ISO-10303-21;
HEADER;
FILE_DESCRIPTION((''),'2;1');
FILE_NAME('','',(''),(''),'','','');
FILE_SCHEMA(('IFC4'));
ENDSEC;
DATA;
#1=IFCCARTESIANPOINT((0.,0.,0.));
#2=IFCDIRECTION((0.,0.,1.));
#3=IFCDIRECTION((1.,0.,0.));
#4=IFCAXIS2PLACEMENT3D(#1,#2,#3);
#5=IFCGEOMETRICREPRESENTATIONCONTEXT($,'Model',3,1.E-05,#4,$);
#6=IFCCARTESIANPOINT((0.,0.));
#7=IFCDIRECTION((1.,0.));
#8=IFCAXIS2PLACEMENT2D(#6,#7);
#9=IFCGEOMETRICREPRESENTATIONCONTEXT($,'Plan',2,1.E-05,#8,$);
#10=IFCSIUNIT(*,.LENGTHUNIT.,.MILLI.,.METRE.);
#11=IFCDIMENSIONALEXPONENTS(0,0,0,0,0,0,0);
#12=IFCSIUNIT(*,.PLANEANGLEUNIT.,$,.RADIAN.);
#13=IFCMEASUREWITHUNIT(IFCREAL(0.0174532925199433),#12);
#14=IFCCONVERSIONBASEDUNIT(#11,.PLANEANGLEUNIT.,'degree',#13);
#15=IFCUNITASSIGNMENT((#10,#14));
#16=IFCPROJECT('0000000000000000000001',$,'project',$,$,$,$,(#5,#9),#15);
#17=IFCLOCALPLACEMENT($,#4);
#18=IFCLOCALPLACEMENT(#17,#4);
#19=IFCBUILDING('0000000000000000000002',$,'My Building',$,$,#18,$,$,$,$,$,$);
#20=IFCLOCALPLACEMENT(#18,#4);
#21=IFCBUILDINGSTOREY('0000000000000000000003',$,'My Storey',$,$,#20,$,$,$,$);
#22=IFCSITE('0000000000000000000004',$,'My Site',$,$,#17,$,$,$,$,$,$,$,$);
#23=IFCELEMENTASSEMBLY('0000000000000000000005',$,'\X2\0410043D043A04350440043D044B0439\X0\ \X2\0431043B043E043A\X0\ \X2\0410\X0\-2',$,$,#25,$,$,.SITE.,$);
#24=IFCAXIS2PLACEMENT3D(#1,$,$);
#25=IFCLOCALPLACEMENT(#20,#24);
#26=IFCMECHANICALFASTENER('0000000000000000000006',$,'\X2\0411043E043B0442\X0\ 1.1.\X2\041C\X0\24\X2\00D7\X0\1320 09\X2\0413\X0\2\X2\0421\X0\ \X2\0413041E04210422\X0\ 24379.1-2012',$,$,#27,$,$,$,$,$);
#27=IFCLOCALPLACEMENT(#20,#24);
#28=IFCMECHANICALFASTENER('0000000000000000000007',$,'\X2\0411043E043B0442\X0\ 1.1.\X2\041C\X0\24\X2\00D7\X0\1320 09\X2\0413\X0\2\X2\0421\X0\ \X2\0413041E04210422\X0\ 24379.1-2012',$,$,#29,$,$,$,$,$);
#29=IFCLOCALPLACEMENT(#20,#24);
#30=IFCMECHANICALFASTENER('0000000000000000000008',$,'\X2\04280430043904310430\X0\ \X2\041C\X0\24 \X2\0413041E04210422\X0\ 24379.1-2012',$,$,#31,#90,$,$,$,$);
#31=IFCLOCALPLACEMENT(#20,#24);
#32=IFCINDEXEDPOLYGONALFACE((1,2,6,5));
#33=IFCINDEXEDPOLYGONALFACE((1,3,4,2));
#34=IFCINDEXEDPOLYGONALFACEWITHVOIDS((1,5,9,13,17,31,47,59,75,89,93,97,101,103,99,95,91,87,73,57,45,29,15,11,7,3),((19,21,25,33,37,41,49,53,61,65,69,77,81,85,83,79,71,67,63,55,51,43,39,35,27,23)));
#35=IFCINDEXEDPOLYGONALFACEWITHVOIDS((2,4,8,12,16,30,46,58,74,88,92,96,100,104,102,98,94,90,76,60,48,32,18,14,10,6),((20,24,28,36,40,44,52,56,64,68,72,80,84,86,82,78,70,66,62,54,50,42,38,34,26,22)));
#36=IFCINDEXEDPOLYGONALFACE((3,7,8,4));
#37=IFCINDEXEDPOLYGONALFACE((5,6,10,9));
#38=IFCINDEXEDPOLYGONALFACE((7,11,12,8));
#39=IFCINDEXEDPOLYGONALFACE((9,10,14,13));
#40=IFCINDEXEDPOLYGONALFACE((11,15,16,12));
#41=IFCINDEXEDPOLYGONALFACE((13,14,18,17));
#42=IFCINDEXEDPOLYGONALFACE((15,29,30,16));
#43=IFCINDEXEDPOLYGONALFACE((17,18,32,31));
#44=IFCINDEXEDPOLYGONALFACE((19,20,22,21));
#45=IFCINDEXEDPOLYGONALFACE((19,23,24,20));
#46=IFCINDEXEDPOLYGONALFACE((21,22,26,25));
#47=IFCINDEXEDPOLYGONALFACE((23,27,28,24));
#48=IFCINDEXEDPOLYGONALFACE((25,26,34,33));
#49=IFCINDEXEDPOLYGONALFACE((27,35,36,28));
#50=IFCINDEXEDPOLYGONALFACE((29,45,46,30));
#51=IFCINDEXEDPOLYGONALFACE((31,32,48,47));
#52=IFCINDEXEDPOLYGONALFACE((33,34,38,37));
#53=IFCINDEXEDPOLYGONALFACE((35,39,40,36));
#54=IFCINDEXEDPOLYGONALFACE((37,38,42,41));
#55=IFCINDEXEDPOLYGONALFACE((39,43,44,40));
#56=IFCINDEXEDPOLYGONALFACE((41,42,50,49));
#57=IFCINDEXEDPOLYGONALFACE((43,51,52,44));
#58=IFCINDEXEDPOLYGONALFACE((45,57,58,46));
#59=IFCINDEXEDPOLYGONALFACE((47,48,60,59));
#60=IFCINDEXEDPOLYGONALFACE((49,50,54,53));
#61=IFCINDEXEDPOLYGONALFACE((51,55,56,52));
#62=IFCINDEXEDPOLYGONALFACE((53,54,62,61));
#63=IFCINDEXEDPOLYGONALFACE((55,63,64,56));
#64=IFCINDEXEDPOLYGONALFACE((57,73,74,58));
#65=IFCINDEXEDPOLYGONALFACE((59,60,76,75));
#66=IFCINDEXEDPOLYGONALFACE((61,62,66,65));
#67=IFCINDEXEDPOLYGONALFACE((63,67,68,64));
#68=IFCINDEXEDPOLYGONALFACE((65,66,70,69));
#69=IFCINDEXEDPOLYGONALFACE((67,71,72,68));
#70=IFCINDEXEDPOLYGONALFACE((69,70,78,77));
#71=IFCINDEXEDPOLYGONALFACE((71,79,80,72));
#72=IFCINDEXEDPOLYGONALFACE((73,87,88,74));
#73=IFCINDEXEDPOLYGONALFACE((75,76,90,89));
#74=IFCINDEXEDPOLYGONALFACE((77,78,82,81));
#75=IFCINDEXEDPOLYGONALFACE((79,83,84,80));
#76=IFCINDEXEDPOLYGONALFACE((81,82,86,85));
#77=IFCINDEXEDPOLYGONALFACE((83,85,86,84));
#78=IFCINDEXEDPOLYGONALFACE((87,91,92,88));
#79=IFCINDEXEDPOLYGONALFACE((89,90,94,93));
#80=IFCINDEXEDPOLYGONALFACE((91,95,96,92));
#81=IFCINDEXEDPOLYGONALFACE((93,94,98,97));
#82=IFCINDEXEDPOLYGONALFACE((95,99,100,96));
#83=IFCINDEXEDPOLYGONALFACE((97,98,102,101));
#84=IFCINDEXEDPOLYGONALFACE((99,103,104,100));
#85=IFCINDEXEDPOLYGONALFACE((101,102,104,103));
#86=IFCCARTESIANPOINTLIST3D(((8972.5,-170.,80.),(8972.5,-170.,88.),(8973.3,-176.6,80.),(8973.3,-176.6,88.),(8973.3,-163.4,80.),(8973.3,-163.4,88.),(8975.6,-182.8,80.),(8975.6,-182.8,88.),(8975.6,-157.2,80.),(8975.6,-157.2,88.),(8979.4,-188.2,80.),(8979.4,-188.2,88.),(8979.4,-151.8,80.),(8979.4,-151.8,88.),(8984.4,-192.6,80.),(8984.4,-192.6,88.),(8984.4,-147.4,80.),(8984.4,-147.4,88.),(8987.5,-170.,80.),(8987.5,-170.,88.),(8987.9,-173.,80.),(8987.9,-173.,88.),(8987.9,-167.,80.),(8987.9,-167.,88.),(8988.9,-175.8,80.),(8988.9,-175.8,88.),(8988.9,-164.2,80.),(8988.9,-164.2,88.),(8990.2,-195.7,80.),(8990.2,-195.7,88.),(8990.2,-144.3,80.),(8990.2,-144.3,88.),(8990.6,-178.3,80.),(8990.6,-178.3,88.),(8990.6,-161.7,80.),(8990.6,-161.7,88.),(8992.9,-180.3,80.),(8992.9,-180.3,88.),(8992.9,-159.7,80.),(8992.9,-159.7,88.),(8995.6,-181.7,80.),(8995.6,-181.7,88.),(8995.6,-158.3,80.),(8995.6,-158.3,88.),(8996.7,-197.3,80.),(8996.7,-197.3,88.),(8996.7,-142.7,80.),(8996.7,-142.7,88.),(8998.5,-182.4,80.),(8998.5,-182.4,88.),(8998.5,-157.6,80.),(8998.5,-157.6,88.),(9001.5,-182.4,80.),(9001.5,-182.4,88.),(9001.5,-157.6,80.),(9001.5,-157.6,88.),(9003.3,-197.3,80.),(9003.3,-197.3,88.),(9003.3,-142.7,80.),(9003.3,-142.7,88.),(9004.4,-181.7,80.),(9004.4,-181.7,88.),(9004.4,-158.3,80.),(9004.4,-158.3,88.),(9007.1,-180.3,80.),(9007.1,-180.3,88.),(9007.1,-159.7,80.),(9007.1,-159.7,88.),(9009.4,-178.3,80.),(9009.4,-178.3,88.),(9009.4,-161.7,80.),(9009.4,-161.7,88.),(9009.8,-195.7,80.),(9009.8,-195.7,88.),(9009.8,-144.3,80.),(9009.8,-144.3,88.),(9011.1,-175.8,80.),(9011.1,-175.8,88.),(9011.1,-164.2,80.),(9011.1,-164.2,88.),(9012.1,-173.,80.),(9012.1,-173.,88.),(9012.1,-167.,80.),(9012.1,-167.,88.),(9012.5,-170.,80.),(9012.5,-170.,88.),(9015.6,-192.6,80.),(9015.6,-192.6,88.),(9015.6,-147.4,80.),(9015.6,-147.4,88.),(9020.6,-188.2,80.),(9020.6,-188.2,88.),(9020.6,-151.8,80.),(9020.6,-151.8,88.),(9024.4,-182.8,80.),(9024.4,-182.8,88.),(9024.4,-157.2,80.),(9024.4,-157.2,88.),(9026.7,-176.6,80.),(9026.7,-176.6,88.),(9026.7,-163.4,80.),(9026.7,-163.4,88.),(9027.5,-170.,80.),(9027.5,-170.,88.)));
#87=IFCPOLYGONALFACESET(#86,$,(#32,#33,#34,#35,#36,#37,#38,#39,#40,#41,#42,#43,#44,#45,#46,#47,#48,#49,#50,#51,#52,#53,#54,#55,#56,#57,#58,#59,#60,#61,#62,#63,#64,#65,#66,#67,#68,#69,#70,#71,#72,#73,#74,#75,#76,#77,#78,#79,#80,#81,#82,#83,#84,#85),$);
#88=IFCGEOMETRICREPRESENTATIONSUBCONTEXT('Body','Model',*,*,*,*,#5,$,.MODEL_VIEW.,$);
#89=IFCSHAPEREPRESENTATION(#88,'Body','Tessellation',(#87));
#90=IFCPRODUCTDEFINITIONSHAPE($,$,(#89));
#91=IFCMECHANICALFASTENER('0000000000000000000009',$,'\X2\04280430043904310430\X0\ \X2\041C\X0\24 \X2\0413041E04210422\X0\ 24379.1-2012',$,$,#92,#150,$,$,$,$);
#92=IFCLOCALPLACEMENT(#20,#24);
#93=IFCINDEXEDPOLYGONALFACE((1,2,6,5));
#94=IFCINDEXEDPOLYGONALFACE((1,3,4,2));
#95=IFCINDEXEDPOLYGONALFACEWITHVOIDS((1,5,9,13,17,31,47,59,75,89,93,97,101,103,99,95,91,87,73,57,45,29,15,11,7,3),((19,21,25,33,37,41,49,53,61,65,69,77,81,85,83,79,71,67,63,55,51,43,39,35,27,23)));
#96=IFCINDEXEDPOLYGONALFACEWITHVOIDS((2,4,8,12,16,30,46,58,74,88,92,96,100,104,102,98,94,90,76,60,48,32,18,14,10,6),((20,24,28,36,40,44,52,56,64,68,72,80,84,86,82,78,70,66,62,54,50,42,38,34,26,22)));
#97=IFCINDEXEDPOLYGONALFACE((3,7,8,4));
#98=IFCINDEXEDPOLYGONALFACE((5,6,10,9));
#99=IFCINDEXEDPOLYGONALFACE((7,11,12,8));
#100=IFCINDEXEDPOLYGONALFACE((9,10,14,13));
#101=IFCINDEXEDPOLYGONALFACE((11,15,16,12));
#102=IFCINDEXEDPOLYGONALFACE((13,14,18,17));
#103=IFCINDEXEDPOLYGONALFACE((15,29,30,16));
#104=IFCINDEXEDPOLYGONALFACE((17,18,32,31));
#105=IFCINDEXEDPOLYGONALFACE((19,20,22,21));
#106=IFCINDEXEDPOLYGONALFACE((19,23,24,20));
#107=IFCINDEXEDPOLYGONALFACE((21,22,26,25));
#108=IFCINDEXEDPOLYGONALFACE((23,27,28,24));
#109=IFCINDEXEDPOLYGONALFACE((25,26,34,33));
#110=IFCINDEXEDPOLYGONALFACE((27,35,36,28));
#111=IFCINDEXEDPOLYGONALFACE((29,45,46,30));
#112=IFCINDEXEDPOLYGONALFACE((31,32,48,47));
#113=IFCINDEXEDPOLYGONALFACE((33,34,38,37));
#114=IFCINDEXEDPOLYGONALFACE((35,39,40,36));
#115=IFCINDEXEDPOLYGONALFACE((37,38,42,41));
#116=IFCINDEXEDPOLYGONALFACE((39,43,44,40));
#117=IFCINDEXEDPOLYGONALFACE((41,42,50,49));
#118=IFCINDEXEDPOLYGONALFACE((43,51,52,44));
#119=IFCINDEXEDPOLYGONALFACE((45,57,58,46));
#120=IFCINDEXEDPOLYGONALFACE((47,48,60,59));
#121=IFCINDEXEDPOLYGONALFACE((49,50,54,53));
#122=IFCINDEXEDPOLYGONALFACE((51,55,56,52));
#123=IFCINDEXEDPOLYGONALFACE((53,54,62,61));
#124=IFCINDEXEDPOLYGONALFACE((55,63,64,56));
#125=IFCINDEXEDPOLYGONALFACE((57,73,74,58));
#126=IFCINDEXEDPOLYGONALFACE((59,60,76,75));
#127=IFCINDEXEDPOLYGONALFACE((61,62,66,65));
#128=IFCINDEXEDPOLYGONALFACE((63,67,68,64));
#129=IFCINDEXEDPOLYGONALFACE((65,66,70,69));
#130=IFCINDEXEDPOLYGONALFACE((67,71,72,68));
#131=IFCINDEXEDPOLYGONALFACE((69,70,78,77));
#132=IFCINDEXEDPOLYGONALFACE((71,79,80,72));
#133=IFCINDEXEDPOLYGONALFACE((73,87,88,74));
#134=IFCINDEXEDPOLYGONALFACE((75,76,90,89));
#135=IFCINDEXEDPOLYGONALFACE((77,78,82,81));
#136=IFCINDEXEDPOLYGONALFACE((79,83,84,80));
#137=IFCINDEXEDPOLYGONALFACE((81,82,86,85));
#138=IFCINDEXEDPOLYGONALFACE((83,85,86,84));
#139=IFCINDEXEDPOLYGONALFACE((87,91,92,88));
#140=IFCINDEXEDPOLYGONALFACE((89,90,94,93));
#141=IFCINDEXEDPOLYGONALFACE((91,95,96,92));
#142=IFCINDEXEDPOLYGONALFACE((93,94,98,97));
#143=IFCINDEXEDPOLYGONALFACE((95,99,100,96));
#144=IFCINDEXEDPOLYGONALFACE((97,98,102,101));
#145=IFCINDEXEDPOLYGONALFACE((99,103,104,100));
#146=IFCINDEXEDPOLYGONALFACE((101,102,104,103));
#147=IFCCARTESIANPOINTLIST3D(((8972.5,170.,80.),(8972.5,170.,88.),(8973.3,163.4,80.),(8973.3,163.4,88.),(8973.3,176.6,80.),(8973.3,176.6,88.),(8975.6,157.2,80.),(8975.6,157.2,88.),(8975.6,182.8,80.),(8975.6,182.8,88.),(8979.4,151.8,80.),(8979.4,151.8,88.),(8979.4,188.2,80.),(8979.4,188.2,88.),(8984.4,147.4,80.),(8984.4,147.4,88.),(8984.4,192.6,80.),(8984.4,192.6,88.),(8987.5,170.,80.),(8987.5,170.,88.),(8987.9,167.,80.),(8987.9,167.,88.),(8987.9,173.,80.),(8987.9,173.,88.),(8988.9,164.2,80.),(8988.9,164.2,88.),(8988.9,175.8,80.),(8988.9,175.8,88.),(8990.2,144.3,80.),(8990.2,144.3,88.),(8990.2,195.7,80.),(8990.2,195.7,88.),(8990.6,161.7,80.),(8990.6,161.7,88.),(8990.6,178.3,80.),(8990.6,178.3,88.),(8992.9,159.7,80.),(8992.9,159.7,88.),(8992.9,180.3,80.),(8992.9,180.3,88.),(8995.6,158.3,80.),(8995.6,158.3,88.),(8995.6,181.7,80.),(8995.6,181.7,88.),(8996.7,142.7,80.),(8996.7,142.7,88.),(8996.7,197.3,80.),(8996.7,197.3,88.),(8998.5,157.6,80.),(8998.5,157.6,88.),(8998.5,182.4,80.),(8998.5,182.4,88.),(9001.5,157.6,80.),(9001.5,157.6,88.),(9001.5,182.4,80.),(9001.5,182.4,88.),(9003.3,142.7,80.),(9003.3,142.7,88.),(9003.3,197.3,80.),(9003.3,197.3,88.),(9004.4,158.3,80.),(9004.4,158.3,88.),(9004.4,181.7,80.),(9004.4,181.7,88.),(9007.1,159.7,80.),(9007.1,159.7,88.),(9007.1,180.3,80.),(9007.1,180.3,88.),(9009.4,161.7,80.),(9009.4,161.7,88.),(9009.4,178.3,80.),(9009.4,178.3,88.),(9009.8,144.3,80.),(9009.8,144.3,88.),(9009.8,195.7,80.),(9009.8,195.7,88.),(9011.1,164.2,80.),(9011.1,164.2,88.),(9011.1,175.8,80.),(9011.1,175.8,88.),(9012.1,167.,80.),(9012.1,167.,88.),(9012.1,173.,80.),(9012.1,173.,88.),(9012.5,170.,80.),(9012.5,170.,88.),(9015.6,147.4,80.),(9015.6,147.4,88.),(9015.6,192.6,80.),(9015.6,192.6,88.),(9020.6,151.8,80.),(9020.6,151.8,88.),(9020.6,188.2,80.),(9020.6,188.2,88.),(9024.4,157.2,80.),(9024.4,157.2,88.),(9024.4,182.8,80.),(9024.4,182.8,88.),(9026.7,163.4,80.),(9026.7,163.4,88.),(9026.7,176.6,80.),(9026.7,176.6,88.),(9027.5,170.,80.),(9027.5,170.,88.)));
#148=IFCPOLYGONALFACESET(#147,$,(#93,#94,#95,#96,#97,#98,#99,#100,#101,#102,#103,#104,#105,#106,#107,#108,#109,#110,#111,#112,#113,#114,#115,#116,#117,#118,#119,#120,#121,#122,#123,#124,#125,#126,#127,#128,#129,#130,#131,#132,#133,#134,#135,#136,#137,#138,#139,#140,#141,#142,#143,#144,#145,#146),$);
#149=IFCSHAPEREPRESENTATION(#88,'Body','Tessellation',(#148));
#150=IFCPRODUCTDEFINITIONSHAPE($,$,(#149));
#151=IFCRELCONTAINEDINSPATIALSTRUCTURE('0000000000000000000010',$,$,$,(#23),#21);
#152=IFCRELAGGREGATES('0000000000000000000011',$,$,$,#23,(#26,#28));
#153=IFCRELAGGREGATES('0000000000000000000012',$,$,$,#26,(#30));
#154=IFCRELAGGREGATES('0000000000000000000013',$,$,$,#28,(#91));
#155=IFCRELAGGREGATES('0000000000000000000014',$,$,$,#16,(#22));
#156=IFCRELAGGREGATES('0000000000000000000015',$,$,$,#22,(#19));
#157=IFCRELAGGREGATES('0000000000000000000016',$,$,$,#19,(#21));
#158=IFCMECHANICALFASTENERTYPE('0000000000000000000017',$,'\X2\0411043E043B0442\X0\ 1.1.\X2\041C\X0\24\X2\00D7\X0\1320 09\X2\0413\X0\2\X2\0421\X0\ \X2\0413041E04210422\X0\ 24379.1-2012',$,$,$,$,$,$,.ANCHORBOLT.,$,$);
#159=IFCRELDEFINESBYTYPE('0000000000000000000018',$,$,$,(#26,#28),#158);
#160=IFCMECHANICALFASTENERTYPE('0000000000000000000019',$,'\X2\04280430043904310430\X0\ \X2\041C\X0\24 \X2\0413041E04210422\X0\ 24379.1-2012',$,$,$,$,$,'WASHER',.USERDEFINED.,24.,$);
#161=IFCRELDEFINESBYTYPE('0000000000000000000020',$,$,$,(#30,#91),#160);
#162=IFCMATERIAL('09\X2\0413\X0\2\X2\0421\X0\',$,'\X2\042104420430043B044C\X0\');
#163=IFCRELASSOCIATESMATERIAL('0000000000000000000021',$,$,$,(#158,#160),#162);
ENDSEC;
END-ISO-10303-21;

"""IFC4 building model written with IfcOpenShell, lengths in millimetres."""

from ifc_helpers import new_model, entity, si_unit, converted_unit, frame, origin_with_axes, origin_2d_with_axis, place, context, subcontext, project, spatial, polyline, outline, extrude, source, transform, mapped, material, type_object, type_shapes, element, aggregate, save


model = new_model("IFC4")

# Units and contexts
model_context = context("Model", 3, precision=1e-05, world=origin_with_axes())
plan_context = context("Plan", 2, precision=1e-05, world=origin_2d_with_axis())
body_context = subcontext(model_context, "Body", "Model", "MODEL_VIEW")
ifc_project = project(units=[si_unit("LENGTHUNIT", "METRE", prefix="MILLI"), converted_unit("PLANEANGLEUNIT", "degree", entity("IfcReal", 0.0174532925199433), si_unit("PLANEANGLEUNIT", "RADIAN"), dimensions=[0, 0, 0, 0, 0, 0, 0])], contexts=[model_context, plan_context])

# Site, building, storey
site_placement = place(None, origin_with_axes())
site = spatial("IfcSite", under=ifc_project, at=site_placement, Name="My Site")
building_placement = place(site_placement, origin_with_axes())
building = spatial("IfcBuilding", under=site, at=building_placement, Name="My Building")
storey_placement = place(building_placement, origin_with_axes())
storey = spatial("IfcBuildingStorey", under=building, at=storey_placement, Name="My Storey")

# Element assembly, mechanical fasteners
ifc_material_1 = material(Name="09Г2С", Category="Сталь")
mechanical_fastener_type_1 = type_object("IfcMechanicalFastenerType", Name="Болт 1.1.М24×1320 09Г2С ГОСТ 24379.1-2012", PredefinedType="ANCHORBOLT", material=ifc_material_1)
assembly_1_placement = place(storey_placement, frame((9000.0, 0.0, 0.0), z_axis=(0.0, 0.0, 1.0), x_axis=(1.0, 0.0, 0.0)))
assembly_1 = element("IfcElementAssembly", 1, at=assembly_1_placement, inside=storey, Name="Анкерный блок А-2", AssemblyPlace="SITE")
mechanical_fastener_1_placement = place(assembly_1_placement, frame((0.0, -170.0, 0.0), z_axis=(0.0, 0.0, 1.0), x_axis=(1.0, 0.0, 0.0)))
mechanical_fastener_1 = element("IfcMechanicalFastener", 2, at=mechanical_fastener_1_placement, type_object=mechanical_fastener_type_1, Name="Болт 1.1.М24×1320 09Г2С ГОСТ 24379.1-2012")
mechanical_fastener_2_placement = place(assembly_1_placement, frame((0.0, 170.0, 0.0), z_axis=(0.0, 0.0, 1.0), x_axis=(-1.0, 0.0, 0.0)))
mechanical_fastener_2 = element("IfcMechanicalFastener", 3, at=mechanical_fastener_2_placement, type_object=mechanical_fastener_type_1, Name="Болт 1.1.М24×1320 09Г2С ГОСТ 24379.1-2012")
aggregate(assembly_1, [mechanical_fastener_1, mechanical_fastener_2])

# Mechanical fasteners
mechanical_fastener_type_2 = type_object("IfcMechanicalFastenerType", Name="Шайба М24 ГОСТ 24379.1-2012", ElementType="WASHER", NominalDiameter=24.0, PredefinedType="USERDEFINED", material=ifc_material_1)
shared_shape_1 = source(origin_with_axes(), body_context, "Body", "SweptSolid", [
    extrude(outline(polyline([(27.5, 0.0), (26.7, 6.6), (24.4, 12.8), (20.6, 18.2), (15.6, 22.6), (9.8, 25.7), (3.3, 27.3), (-3.3, 27.3), (-9.8, 25.7), (-15.6, 22.6), (-20.6, 18.2), (-24.4, 12.8), (-26.7, 6.6), (-27.5, 0.0), (-26.7, -6.6), (-24.4, -12.8), (-20.6, -18.2), (-15.6, -22.6), (-9.8, -25.7), (-3.3, -27.3), (3.3, -27.3), (9.8, -25.7), (15.6, -22.6), (20.6, -18.2), (24.4, -12.8), (26.7, -6.6), (27.5, 0.0)]), holes=[polyline([(-4.4, -11.7), (-7.1, -10.3), (-9.4, -8.3), (-11.1, -5.8), (-12.1, -3.0), (-12.5, 0.0), (-12.1, 3.0), (-11.1, 5.8), (-9.4, 8.3), (-7.1, 10.3), (-4.4, 11.7), (-1.5, 12.4), (1.5, 12.4), (4.4, 11.7), (7.1, 10.3), (9.4, 8.3), (11.1, 5.8), (12.1, 3.0), (12.5, 0.0), (12.1, -3.0), (11.1, -5.8), (9.4, -8.3), (7.1, -10.3), (4.4, -11.7), (1.5, -12.4), (-1.5, -12.4), (-4.4, -11.7)])]), frame((0.0, 0.0, 0.0), z_axis=(0.0, 0.0, 1.0), x_axis=(0.120537, -0.992709, 0.0)), (0.0, 0.0, 1.0), 8.0),
])
type_shapes(mechanical_fastener_type_2, [shared_shape_1])
mechanical_fastener_3_placement = place(mechanical_fastener_1_placement, frame((0.0, 0.0, 80.0), z_axis=(0.0, 0.0, 1.0), x_axis=(1.0, 0.0, 0.0)))
mechanical_fastener_3 = element("IfcMechanicalFastener", 4, at=mechanical_fastener_3_placement, type_object=mechanical_fastener_type_2, Name="Шайба М24 ГОСТ 24379.1-2012", context=body_context, shape_type="MappedRepresentation", body=[
    mapped(shared_shape_1, transform((0.0, 0.0, 0.0), x_axis=(1.0, 0.0, 0.0), y_axis=(0.0, 1.0, 0.0), z_axis=(0.0, 0.0, 1.0), scale=1.0)),
])
aggregate(mechanical_fastener_1, [mechanical_fastener_3])
mechanical_fastener_4_placement = place(mechanical_fastener_2_placement, frame((0.0, 0.0, 80.0), z_axis=(0.0, 0.0, 1.0), x_axis=(1.0, 0.0, 0.0)))
mechanical_fastener_4 = element("IfcMechanicalFastener", 5, at=mechanical_fastener_4_placement, type_object=mechanical_fastener_type_2, Name="Шайба М24 ГОСТ 24379.1-2012", context=body_context, shape_type="MappedRepresentation", body=[
    mapped(shared_shape_1, transform((0.0, 0.0, 0.0), x_axis=(1.0, 0.0, 0.0), y_axis=(0.0, 1.0, 0.0), z_axis=(0.0, 0.0, 1.0), scale=1.0)),
])
aggregate(mechanical_fastener_2, [mechanical_fastener_4])

save(model, "model.ifc")
